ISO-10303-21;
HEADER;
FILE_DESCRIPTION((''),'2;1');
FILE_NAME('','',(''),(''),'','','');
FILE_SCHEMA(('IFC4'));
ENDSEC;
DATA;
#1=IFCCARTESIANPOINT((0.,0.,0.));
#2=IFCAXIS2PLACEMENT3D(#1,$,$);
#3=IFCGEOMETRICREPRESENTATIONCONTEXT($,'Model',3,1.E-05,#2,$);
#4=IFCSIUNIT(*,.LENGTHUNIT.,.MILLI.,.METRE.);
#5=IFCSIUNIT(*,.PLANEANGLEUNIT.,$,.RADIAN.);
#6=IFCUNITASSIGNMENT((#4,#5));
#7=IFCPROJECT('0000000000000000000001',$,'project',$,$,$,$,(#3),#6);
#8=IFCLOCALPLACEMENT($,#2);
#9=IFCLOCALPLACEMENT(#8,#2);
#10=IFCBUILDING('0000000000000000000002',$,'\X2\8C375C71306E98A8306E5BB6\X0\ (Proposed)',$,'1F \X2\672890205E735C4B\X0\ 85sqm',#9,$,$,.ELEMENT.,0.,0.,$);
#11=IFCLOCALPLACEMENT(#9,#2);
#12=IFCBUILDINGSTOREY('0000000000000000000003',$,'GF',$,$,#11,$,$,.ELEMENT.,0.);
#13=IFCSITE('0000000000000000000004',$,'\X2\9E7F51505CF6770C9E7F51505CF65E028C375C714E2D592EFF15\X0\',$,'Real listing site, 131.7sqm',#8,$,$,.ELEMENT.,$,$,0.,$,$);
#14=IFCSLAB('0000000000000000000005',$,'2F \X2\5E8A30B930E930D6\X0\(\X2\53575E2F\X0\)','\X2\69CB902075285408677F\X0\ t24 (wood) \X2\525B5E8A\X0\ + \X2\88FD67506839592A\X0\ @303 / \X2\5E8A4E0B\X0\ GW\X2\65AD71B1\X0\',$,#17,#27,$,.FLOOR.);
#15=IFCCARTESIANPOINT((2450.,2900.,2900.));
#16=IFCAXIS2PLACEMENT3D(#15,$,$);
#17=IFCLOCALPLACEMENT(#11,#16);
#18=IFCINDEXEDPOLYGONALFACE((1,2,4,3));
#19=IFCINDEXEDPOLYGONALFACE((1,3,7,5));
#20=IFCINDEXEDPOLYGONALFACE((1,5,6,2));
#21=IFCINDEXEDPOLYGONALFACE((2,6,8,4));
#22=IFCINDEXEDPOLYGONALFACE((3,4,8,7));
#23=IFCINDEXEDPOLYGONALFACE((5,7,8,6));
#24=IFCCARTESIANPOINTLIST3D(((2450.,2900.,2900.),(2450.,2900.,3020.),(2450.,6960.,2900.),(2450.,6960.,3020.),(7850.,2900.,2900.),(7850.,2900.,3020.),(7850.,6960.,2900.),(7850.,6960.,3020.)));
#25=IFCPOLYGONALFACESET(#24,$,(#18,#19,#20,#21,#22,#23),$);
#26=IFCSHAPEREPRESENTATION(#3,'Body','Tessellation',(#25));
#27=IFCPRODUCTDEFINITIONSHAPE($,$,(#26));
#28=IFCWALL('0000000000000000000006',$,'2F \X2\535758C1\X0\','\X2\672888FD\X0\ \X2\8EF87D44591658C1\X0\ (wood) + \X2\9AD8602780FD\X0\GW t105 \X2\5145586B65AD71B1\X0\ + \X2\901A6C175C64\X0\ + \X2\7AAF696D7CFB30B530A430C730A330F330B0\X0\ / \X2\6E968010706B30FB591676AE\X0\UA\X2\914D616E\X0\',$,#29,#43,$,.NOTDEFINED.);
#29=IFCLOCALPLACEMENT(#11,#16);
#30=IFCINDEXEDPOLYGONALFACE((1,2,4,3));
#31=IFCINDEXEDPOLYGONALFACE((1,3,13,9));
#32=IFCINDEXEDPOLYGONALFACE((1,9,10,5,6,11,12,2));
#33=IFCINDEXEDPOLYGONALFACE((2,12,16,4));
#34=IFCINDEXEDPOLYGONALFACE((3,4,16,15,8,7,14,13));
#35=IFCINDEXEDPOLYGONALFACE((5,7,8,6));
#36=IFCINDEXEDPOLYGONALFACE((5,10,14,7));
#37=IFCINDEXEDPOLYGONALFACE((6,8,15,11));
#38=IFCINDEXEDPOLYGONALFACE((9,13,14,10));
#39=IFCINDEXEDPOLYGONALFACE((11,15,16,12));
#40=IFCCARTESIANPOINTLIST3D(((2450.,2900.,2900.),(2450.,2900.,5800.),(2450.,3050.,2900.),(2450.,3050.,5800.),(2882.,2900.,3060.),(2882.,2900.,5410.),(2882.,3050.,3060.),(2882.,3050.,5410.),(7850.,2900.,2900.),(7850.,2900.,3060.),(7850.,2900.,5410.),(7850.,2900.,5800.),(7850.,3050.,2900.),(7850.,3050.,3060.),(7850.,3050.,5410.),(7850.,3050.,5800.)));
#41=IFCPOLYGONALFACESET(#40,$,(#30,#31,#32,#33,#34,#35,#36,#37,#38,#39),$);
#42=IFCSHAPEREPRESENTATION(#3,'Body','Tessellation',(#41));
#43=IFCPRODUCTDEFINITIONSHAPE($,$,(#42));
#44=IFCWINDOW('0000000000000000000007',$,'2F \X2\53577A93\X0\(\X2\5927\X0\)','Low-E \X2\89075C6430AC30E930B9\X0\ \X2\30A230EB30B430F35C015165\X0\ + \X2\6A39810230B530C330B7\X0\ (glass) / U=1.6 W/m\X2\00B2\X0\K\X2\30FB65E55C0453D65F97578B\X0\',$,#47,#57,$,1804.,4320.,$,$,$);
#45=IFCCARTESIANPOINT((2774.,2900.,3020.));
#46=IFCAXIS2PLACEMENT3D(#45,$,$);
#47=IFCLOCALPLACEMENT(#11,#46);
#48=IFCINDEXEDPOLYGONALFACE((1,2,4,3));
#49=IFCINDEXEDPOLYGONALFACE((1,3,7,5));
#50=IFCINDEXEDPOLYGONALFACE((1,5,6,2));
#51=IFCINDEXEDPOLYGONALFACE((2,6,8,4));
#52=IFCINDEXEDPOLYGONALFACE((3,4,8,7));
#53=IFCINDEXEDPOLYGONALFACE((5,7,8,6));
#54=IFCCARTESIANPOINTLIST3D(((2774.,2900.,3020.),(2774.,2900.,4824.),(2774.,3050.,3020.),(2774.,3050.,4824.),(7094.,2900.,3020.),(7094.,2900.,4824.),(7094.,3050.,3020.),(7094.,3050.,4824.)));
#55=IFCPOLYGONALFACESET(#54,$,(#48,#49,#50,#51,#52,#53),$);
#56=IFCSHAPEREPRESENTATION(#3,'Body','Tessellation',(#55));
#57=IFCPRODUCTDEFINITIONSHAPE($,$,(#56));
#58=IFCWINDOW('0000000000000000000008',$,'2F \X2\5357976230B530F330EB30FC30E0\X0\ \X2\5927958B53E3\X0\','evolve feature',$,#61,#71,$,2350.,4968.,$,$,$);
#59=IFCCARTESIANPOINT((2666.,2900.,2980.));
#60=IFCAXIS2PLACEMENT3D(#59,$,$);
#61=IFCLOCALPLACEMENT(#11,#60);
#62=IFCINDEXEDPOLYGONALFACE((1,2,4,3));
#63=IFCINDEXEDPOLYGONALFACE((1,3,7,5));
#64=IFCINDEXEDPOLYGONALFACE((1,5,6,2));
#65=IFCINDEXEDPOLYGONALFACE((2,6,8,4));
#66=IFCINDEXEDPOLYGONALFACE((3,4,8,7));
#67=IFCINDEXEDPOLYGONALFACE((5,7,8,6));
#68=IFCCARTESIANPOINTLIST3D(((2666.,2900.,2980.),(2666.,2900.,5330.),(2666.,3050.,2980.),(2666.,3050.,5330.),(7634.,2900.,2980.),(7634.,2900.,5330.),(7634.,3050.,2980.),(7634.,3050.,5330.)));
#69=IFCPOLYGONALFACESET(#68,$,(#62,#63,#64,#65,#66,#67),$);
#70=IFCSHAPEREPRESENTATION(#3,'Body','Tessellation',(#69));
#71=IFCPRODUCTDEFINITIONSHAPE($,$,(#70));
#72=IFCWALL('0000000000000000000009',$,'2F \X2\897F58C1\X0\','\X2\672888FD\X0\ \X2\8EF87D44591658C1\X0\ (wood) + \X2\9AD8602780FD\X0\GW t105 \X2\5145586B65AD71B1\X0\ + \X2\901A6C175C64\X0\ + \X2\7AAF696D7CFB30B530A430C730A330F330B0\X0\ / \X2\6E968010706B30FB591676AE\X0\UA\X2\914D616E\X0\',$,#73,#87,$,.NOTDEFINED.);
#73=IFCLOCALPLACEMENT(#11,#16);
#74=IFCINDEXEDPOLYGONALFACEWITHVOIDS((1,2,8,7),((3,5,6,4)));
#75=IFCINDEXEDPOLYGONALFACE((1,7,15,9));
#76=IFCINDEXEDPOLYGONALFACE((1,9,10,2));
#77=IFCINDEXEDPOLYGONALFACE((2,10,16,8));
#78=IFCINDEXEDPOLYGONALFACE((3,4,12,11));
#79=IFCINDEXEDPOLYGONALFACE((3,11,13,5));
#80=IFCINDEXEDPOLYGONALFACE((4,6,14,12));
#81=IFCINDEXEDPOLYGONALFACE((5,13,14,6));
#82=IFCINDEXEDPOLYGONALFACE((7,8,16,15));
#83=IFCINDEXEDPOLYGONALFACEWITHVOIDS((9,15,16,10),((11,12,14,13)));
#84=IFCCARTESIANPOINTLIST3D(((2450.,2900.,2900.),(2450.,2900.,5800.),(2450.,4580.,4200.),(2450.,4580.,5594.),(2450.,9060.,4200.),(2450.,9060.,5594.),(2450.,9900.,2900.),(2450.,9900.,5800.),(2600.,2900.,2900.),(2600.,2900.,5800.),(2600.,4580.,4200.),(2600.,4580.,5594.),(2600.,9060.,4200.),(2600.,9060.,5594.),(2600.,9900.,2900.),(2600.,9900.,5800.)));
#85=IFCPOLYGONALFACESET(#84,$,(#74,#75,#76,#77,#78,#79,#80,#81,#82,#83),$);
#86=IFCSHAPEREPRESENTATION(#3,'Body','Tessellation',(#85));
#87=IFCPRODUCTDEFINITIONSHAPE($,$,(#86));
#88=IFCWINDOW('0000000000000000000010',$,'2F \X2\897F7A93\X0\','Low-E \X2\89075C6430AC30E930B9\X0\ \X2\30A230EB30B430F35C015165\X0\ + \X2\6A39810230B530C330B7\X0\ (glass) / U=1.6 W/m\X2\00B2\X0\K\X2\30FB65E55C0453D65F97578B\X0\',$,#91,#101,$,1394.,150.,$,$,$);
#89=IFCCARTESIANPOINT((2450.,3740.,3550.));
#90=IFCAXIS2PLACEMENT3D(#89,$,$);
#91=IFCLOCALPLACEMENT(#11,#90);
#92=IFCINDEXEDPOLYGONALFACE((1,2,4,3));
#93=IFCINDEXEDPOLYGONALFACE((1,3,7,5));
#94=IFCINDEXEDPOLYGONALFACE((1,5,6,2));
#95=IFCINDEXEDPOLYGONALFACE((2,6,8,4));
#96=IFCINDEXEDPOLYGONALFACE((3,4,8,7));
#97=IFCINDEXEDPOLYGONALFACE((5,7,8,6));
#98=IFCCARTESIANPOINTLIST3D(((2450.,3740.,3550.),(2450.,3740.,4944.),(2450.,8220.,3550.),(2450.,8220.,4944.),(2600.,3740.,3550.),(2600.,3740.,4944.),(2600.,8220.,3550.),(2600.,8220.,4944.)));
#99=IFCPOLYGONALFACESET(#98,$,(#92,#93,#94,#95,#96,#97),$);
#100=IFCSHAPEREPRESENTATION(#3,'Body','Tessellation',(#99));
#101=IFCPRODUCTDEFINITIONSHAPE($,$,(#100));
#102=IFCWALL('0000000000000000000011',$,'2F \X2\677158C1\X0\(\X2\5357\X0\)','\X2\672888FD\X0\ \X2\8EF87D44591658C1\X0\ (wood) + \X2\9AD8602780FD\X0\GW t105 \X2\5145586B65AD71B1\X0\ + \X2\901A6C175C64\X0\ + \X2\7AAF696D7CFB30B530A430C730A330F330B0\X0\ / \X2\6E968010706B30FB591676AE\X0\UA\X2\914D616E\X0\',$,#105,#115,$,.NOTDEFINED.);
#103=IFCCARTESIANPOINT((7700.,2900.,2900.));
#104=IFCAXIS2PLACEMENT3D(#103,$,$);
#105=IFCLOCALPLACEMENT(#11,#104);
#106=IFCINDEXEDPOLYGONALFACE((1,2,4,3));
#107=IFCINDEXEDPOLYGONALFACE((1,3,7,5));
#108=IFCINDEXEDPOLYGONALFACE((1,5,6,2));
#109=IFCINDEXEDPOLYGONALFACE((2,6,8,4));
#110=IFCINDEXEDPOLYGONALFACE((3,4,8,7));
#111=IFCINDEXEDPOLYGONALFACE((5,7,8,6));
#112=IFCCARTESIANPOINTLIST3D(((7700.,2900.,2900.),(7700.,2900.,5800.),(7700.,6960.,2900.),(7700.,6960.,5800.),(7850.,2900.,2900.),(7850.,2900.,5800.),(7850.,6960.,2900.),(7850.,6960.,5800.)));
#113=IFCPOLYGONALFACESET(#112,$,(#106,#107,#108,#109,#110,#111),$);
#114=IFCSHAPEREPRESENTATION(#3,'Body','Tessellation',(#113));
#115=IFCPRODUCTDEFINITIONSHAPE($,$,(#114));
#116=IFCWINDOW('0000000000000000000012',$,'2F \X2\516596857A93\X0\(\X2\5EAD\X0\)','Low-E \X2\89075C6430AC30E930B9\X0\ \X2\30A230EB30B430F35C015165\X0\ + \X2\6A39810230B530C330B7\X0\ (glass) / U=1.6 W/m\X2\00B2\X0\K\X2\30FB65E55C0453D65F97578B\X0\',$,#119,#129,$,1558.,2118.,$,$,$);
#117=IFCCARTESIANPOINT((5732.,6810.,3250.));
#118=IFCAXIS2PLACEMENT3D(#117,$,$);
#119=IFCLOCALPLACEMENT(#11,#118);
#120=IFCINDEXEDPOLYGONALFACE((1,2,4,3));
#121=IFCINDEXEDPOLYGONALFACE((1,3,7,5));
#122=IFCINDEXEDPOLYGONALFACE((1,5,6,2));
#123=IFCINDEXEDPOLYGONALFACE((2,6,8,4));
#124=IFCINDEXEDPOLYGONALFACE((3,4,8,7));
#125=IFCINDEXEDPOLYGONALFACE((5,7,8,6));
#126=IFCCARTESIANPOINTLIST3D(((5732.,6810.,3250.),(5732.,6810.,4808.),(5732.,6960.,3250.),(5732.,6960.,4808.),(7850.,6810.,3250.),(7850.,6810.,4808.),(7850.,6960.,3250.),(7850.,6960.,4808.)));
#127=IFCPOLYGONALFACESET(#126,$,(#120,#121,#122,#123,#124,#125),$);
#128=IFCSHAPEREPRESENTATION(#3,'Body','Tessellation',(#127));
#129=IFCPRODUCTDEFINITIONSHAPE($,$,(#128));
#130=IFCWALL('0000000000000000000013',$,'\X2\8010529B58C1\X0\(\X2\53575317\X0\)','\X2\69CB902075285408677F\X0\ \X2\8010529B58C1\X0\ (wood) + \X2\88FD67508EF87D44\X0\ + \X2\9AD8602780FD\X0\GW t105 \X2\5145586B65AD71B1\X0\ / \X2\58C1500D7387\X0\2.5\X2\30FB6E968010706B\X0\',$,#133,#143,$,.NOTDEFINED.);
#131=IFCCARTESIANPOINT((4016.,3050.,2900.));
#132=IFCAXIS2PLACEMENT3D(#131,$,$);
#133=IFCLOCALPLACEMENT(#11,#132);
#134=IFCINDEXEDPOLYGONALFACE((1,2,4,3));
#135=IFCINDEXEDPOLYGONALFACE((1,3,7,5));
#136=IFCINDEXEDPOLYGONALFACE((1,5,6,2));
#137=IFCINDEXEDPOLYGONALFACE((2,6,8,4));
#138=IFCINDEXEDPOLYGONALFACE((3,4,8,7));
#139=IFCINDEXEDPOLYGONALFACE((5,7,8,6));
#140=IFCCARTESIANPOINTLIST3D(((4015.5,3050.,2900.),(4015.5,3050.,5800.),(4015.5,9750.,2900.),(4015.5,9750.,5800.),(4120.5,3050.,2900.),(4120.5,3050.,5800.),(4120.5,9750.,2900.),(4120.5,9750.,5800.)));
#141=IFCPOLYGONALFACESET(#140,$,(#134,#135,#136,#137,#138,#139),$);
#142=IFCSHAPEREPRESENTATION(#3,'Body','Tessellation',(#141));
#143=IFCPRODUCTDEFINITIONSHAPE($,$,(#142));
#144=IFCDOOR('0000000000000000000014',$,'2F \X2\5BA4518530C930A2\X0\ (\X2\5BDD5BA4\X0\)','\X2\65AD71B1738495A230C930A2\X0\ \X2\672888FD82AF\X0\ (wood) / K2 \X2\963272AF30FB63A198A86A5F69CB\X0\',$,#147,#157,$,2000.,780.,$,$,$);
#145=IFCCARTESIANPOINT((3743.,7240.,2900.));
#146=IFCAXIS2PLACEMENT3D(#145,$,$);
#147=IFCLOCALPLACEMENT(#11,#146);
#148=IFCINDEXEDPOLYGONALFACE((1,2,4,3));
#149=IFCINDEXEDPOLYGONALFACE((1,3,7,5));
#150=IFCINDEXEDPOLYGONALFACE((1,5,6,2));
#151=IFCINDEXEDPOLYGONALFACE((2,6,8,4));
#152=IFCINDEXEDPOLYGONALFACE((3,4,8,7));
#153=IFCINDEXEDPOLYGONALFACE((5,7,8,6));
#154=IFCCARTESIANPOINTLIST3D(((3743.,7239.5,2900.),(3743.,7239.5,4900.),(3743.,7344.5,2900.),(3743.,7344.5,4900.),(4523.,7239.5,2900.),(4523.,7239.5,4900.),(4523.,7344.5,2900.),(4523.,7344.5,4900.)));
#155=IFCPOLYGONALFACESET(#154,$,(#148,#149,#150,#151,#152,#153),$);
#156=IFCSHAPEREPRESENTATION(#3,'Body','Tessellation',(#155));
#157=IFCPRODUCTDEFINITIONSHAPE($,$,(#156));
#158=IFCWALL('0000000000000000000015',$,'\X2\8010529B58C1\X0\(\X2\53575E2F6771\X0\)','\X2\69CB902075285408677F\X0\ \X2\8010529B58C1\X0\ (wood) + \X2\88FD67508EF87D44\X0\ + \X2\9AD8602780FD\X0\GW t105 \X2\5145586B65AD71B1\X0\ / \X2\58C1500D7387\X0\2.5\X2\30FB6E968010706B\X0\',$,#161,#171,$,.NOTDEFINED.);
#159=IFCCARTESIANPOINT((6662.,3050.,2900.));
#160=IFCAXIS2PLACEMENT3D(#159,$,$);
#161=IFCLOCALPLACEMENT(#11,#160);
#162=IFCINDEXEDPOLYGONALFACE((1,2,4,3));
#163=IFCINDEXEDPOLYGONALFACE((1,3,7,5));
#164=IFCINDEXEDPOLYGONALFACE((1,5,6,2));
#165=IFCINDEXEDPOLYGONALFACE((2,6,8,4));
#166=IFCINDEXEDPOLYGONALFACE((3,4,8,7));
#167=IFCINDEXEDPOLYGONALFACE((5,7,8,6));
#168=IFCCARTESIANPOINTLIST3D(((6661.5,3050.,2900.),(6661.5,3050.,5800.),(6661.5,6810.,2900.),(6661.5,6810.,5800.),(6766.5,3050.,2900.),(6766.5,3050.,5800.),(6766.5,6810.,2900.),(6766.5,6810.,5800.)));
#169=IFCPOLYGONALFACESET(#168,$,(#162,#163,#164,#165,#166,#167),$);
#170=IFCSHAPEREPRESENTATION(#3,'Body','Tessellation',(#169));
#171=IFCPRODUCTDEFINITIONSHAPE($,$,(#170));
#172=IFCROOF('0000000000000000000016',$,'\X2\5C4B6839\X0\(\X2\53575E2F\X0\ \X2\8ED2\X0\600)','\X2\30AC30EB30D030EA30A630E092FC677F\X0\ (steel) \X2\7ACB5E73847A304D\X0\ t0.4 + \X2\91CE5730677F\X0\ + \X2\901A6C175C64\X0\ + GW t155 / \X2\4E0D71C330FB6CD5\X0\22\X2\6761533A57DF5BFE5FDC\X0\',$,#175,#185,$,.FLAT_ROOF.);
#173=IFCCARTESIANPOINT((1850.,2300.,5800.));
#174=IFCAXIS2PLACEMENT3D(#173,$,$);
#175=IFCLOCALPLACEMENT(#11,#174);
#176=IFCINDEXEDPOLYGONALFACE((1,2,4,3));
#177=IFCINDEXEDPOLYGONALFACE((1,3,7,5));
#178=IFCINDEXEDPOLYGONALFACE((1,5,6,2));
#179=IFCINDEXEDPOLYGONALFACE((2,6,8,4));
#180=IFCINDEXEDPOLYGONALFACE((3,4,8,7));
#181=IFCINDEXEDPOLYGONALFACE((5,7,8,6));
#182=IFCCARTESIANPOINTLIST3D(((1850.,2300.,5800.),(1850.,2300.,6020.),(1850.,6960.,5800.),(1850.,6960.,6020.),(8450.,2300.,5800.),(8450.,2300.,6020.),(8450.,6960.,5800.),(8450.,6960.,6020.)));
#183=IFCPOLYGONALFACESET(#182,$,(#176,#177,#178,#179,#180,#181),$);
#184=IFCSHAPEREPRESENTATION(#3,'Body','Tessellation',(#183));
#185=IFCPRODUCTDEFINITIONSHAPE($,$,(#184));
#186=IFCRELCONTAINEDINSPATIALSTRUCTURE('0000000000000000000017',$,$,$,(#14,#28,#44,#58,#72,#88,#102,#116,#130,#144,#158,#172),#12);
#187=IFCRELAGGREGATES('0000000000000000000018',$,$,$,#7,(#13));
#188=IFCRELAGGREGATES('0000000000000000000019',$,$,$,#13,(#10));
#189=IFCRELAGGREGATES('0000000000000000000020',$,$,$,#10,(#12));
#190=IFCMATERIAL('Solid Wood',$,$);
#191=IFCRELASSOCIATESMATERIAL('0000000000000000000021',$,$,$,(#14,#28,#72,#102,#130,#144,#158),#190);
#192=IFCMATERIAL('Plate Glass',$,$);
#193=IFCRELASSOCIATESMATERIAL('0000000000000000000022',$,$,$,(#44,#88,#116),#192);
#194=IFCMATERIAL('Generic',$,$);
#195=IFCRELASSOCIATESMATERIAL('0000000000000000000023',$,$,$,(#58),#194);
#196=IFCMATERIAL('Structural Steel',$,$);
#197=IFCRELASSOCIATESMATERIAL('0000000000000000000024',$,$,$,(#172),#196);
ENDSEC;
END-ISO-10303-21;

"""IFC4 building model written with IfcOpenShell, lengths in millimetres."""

from ifc_helpers import new_model, si_unit, frame, frame_2d, origin, place, context, project, spatial, rectangle, extrude, material, element, fill, save


model = new_model("IFC4")

# Units and contexts
model_context = context("Model", 3, precision=1e-05, world=origin())
ifc_project = project(units=[si_unit("LENGTHUNIT", "METRE", prefix="MILLI"), si_unit("PLANEANGLEUNIT", "RADIAN")], contexts=[model_context])

# Site, building, storey
site_placement = place(None, origin())
site = spatial("IfcSite", under=ifc_project, at=site_placement, Name="鹿児島県鹿児島市谷山中央５", ObjectType="Real listing site, 131.7sqm", CompositionType="ELEMENT", RefElevation=0.0)
building_placement = place(site_placement, origin())
building = spatial("IfcBuilding", under=site, at=building_placement, Name="谷山の風の家 (Proposed)", ObjectType="1F 木造平屋 85sqm", CompositionType="ELEMENT", ElevationOfRefHeight=0.0, ElevationOfTerrain=0.0)
storey_placement = place(building_placement, origin())
storey = spatial("IfcBuildingStorey", under=building, at=storey_placement, Name="GF", CompositionType="ELEMENT", Elevation=0.0)

# Slab
ifc_material_1 = material(Name="Solid Wood")
slab_placement = place(storey_placement, frame((2450.0, 2900.0, 2900.0)))
element("IfcSlab", 1, at=slab_placement, inside=storey, material=ifc_material_1, Name="2F 床スラブ(南帯)", Description="構造用合板 t24 (wood) 剛床 + 製材根太 @303 / 床下 GW断熱", PredefinedType="FLOOR", context=model_context, shape_type="SweptSolid", body=[
    extrude(rectangle(XDim=5400.0, YDim=4060.0, at=frame_2d((2700.0, 2030.0))), frame((2450.0, 2900.0, 2900.0)), (0.0, 0.0, 1.0), 120.0),
])

# Wall, openings, windows
wall_1_placement = place(storey_placement, frame((2450.0, 2900.0, 2900.0)))
wall_1 = element("IfcWall", 2, at=wall_1_placement, inside=storey, material=ifc_material_1, Name="2F 南壁", Description="木製 軸組外壁 (wood) + 高性能GW t105 充填断熱 + 通気層 + 窯業系サイディング / 準耐火・外皮UA配慮", PredefinedType="NOTDEFINED", context=model_context, shape_type="SweptSolid", body=[
    extrude(rectangle(XDim=5400.0, YDim=150.0, at=frame_2d((2700.0, 75.0))), frame((2450.0, 2900.0, 2900.0)), (0.0, 0.0, 1.0), 2900.0),
])
opening_1_placement = place(storey_placement, frame((2774.0, 2900.0, 3020.0)))
opening_1 = element("IfcOpeningElement", 3, at=opening_1_placement, cuts=wall_1, PredefinedType="NOTDEFINED", context=model_context, shape_type="SweptSolid", body=[
    extrude(rectangle(XDim=4320.0, YDim=150.0, at=frame_2d((2160.0, 75.0))), frame((2774.0, 2900.0, 3020.0)), (0.0, 0.0, 1.0), 1804.0),
])
opening_2_placement = place(storey_placement, frame((2666.0, 2900.0, 2980.0)))
opening_2 = element("IfcOpeningElement", 4, at=opening_2_placement, cuts=wall_1, PredefinedType="NOTDEFINED", context=model_context, shape_type="SweptSolid", body=[
    extrude(rectangle(XDim=4968.0, YDim=150.0, at=frame_2d((2484.0, 75.0))), frame((2666.0, 2900.0, 2980.0)), (0.0, 0.0, 1.0), 2350.0),
])
ifc_material_2 = material(Name="Plate Glass")
window_1_placement = place(storey_placement, frame((2774.0, 2900.0, 3020.0)))
window_1 = element("IfcWindow", 5, at=window_1_placement, inside=storey, material=ifc_material_2, Name="2F 南窓(大)", Description="Low-E 複層ガラス アルゴン封入 + 樹脂サッシ (glass) / U=1.6 W/m²K・日射取得型", OverallHeight=1804.0, OverallWidth=4320.0, context=model_context, shape_type="SweptSolid", body=[
    extrude(rectangle(XDim=4320.0, YDim=150.0, at=frame_2d((2160.0, 75.0))), frame((2774.0, 2900.0, 3020.0)), (0.0, 0.0, 1.0), 1804.0),
])
fill(opening_1, window_1)
ifc_material_3 = material(Name="Generic")
window_2_placement = place(storey_placement, frame((2666.0, 2900.0, 2980.0)))
window_2 = element("IfcWindow", 6, at=window_2_placement, inside=storey, material=ifc_material_3, Name="2F 南面サンルーム 大開口", Description="evolve feature", OverallHeight=2350.0, OverallWidth=4968.0, context=model_context, shape_type="SweptSolid", body=[
    extrude(rectangle(XDim=4968.0, YDim=150.0, at=frame_2d((2484.0, 75.0))), frame((2666.0, 2900.0, 2980.0)), (0.0, 0.0, 1.0), 2350.0),
])
fill(opening_2, window_2)

# Walls, openings, windows
wall_2_placement = place(storey_placement, frame((2450.0, 2900.0, 2900.0)))
wall_2 = element("IfcWall", 7, at=wall_2_placement, inside=storey, material=ifc_material_1, Name="2F 西壁", Description="木製 軸組外壁 (wood) + 高性能GW t105 充填断熱 + 通気層 + 窯業系サイディング / 準耐火・外皮UA配慮", PredefinedType="NOTDEFINED", context=model_context, shape_type="SweptSolid", body=[
    extrude(rectangle(XDim=150.0, YDim=7000.0, at=frame_2d((75.0, 3500.0))), frame((2450.0, 2900.0, 2900.0)), (0.0, 0.0, 1.0), 2900.0),
])
opening_3_placement = place(storey_placement, frame((2450.0, 3740.0, 3550.0)))
opening_3 = element("IfcOpeningElement", 8, at=opening_3_placement, cuts=wall_2, PredefinedType="NOTDEFINED", context=model_context, shape_type="SweptSolid", body=[
    extrude(rectangle(XDim=150.0, YDim=4480.0, at=frame_2d((75.0, 2240.0))), frame((2450.0, 3740.0, 3550.0)), (0.0, 0.0, 1.0), 1394.0),
])
window_3_placement = place(storey_placement, frame((2450.0, 3740.0, 3550.0)))
window_3 = element("IfcWindow", 9, at=window_3_placement, inside=storey, material=ifc_material_2, Name="2F 西窓", Description="Low-E 複層ガラス アルゴン封入 + 樹脂サッシ (glass) / U=1.6 W/m²K・日射取得型", OverallHeight=1394.0, OverallWidth=150.0, context=model_context, shape_type="SweptSolid", body=[
    extrude(rectangle(XDim=150.0, YDim=4480.0, at=frame_2d((75.0, 2240.0))), frame((2450.0, 3740.0, 3550.0)), (0.0, 0.0, 1.0), 1394.0),
])
fill(opening_3, window_3)
wall_3_placement = place(storey_placement, frame((7700.0, 2900.0, 2900.0)))
wall_3 = element("IfcWall", 10, at=wall_3_placement, inside=storey, material=ifc_material_1, Name="2F 東壁(南)", Description="木製 軸組外壁 (wood) + 高性能GW t105 充填断熱 + 通気層 + 窯業系サイディング / 準耐火・外皮UA配慮", PredefinedType="NOTDEFINED", context=model_context, shape_type="SweptSolid", body=[
    extrude(rectangle(XDim=150.0, YDim=4060.0, at=frame_2d((75.0, 2030.0))), frame((7700.0, 2900.0, 2900.0)), (0.0, 0.0, 1.0), 2900.0),
])
opening_4_placement = place(storey_placement, frame((5732.0, 6810.0, 3250.0)))
opening_4 = element("IfcOpeningElement", 11, at=opening_4_placement, cuts=wall_3, PredefinedType="NOTDEFINED", context=model_context, shape_type="SweptSolid", body=[
    extrude(rectangle(XDim=2118.0, YDim=150.0, at=frame_2d((1059.0, 75.0))), frame((5732.0, 6810.0, 3250.0)), (0.0, 0.0, 1.0), 1558.0),
])
window_4_placement = place(storey_placement, frame((5732.0, 6810.0, 3250.0)))
window_4 = element("IfcWindow", 12, at=window_4_placement, inside=storey, material=ifc_material_2, Name="2F 入隅窓(庭)", Description="Low-E 複層ガラス アルゴン封入 + 樹脂サッシ (glass) / U=1.6 W/m²K・日射取得型", OverallHeight=1558.0, OverallWidth=2118.0, context=model_context, shape_type="SweptSolid", body=[
    extrude(rectangle(XDim=2118.0, YDim=150.0, at=frame_2d((1059.0, 75.0))), frame((5732.0, 6810.0, 3250.0)), (0.0, 0.0, 1.0), 1558.0),
])
fill(opening_4, window_4)

# Wall, opening, door
wall_4_placement = place(storey_placement, frame((4016.0, 3050.0, 2900.0)))
wall_4 = element("IfcWall", 13, at=wall_4_placement, inside=storey, material=ifc_material_1, Name="耐力壁(南北)", Description="構造用合板 耐力壁 (wood) + 製材軸組 + 高性能GW t105 充填断熱 / 壁倍率2.5・準耐火", PredefinedType="NOTDEFINED", context=model_context, shape_type="SweptSolid", body=[
    extrude(rectangle(XDim=105.0, YDim=6700.0, at=frame_2d((52.0, 3350.0))), frame((4016.0, 3050.0, 2900.0)), (0.0, 0.0, 1.0), 2900.0),
])
opening_5_placement = place(storey_placement, frame((3743.0, 7240.0, 2900.0)))
opening_5 = element("IfcOpeningElement", 14, at=opening_5_placement, cuts=wall_4, PredefinedType="NOTDEFINED", context=model_context, shape_type="SweptSolid", body=[
    extrude(rectangle(XDim=780.0, YDim=105.0, at=frame_2d((390.0, 52.0))), frame((3743.0, 7240.0, 2900.0)), (0.0, 0.0, 1.0), 2000.0),
])
door_placement = place(storey_placement, frame((3743.0, 7240.0, 2900.0)))
door = element("IfcDoor", 15, at=door_placement, inside=storey, material=ifc_material_1, Name="2F 室内ドア (寝室)", Description="断熱玄関ドア 木製芯 (wood) / K2 防犯・採風機構", OverallHeight=2000.0, OverallWidth=780.0, context=model_context, shape_type="SweptSolid", body=[
    extrude(rectangle(XDim=780.0, YDim=105.0, at=frame_2d((390.0, 52.0))), frame((3743.0, 7240.0, 2900.0)), (0.0, 0.0, 1.0), 2000.0),
])
fill(opening_5, door)

# Wall
wall_5_placement = place(storey_placement, frame((6662.0, 3050.0, 2900.0)))
element("IfcWall", 16, at=wall_5_placement, inside=storey, material=ifc_material_1, Name="耐力壁(南帯東)", Description="構造用合板 耐力壁 (wood) + 製材軸組 + 高性能GW t105 充填断熱 / 壁倍率2.5・準耐火", PredefinedType="NOTDEFINED", context=model_context, shape_type="SweptSolid", body=[
    extrude(rectangle(XDim=105.0, YDim=3760.0, at=frame_2d((52.0, 1880.0))), frame((6662.0, 3050.0, 2900.0)), (0.0, 0.0, 1.0), 2900.0),
])

# Roof
ifc_material_4 = material(Name="Structural Steel")
for number, where, name in (
    (17, (1850.0, 2300.0, 5800.0), "屋根(南帯 軒600)"),
):
    element("IfcRoof", number, at=place(storey_placement, frame(where)), inside=storey, material=ifc_material_4, Name=name, Description="ガルバリウム鋼板 (steel) 立平葺き t0.4 + 野地板 + 通気層 + GW t155 / 不燃・法22条区域対応", PredefinedType="FLAT_ROOF", context=model_context, shape_type="SweptSolid", body=[
        extrude(rectangle(XDim=6600.0, YDim=4660.0, at=frame_2d((3300.0, 2330.0))), frame((1850.0, 2300.0, 5800.0)), (0.0, 0.0, 1.0), 220.0),
    ])

save(model, "model.ifc")
